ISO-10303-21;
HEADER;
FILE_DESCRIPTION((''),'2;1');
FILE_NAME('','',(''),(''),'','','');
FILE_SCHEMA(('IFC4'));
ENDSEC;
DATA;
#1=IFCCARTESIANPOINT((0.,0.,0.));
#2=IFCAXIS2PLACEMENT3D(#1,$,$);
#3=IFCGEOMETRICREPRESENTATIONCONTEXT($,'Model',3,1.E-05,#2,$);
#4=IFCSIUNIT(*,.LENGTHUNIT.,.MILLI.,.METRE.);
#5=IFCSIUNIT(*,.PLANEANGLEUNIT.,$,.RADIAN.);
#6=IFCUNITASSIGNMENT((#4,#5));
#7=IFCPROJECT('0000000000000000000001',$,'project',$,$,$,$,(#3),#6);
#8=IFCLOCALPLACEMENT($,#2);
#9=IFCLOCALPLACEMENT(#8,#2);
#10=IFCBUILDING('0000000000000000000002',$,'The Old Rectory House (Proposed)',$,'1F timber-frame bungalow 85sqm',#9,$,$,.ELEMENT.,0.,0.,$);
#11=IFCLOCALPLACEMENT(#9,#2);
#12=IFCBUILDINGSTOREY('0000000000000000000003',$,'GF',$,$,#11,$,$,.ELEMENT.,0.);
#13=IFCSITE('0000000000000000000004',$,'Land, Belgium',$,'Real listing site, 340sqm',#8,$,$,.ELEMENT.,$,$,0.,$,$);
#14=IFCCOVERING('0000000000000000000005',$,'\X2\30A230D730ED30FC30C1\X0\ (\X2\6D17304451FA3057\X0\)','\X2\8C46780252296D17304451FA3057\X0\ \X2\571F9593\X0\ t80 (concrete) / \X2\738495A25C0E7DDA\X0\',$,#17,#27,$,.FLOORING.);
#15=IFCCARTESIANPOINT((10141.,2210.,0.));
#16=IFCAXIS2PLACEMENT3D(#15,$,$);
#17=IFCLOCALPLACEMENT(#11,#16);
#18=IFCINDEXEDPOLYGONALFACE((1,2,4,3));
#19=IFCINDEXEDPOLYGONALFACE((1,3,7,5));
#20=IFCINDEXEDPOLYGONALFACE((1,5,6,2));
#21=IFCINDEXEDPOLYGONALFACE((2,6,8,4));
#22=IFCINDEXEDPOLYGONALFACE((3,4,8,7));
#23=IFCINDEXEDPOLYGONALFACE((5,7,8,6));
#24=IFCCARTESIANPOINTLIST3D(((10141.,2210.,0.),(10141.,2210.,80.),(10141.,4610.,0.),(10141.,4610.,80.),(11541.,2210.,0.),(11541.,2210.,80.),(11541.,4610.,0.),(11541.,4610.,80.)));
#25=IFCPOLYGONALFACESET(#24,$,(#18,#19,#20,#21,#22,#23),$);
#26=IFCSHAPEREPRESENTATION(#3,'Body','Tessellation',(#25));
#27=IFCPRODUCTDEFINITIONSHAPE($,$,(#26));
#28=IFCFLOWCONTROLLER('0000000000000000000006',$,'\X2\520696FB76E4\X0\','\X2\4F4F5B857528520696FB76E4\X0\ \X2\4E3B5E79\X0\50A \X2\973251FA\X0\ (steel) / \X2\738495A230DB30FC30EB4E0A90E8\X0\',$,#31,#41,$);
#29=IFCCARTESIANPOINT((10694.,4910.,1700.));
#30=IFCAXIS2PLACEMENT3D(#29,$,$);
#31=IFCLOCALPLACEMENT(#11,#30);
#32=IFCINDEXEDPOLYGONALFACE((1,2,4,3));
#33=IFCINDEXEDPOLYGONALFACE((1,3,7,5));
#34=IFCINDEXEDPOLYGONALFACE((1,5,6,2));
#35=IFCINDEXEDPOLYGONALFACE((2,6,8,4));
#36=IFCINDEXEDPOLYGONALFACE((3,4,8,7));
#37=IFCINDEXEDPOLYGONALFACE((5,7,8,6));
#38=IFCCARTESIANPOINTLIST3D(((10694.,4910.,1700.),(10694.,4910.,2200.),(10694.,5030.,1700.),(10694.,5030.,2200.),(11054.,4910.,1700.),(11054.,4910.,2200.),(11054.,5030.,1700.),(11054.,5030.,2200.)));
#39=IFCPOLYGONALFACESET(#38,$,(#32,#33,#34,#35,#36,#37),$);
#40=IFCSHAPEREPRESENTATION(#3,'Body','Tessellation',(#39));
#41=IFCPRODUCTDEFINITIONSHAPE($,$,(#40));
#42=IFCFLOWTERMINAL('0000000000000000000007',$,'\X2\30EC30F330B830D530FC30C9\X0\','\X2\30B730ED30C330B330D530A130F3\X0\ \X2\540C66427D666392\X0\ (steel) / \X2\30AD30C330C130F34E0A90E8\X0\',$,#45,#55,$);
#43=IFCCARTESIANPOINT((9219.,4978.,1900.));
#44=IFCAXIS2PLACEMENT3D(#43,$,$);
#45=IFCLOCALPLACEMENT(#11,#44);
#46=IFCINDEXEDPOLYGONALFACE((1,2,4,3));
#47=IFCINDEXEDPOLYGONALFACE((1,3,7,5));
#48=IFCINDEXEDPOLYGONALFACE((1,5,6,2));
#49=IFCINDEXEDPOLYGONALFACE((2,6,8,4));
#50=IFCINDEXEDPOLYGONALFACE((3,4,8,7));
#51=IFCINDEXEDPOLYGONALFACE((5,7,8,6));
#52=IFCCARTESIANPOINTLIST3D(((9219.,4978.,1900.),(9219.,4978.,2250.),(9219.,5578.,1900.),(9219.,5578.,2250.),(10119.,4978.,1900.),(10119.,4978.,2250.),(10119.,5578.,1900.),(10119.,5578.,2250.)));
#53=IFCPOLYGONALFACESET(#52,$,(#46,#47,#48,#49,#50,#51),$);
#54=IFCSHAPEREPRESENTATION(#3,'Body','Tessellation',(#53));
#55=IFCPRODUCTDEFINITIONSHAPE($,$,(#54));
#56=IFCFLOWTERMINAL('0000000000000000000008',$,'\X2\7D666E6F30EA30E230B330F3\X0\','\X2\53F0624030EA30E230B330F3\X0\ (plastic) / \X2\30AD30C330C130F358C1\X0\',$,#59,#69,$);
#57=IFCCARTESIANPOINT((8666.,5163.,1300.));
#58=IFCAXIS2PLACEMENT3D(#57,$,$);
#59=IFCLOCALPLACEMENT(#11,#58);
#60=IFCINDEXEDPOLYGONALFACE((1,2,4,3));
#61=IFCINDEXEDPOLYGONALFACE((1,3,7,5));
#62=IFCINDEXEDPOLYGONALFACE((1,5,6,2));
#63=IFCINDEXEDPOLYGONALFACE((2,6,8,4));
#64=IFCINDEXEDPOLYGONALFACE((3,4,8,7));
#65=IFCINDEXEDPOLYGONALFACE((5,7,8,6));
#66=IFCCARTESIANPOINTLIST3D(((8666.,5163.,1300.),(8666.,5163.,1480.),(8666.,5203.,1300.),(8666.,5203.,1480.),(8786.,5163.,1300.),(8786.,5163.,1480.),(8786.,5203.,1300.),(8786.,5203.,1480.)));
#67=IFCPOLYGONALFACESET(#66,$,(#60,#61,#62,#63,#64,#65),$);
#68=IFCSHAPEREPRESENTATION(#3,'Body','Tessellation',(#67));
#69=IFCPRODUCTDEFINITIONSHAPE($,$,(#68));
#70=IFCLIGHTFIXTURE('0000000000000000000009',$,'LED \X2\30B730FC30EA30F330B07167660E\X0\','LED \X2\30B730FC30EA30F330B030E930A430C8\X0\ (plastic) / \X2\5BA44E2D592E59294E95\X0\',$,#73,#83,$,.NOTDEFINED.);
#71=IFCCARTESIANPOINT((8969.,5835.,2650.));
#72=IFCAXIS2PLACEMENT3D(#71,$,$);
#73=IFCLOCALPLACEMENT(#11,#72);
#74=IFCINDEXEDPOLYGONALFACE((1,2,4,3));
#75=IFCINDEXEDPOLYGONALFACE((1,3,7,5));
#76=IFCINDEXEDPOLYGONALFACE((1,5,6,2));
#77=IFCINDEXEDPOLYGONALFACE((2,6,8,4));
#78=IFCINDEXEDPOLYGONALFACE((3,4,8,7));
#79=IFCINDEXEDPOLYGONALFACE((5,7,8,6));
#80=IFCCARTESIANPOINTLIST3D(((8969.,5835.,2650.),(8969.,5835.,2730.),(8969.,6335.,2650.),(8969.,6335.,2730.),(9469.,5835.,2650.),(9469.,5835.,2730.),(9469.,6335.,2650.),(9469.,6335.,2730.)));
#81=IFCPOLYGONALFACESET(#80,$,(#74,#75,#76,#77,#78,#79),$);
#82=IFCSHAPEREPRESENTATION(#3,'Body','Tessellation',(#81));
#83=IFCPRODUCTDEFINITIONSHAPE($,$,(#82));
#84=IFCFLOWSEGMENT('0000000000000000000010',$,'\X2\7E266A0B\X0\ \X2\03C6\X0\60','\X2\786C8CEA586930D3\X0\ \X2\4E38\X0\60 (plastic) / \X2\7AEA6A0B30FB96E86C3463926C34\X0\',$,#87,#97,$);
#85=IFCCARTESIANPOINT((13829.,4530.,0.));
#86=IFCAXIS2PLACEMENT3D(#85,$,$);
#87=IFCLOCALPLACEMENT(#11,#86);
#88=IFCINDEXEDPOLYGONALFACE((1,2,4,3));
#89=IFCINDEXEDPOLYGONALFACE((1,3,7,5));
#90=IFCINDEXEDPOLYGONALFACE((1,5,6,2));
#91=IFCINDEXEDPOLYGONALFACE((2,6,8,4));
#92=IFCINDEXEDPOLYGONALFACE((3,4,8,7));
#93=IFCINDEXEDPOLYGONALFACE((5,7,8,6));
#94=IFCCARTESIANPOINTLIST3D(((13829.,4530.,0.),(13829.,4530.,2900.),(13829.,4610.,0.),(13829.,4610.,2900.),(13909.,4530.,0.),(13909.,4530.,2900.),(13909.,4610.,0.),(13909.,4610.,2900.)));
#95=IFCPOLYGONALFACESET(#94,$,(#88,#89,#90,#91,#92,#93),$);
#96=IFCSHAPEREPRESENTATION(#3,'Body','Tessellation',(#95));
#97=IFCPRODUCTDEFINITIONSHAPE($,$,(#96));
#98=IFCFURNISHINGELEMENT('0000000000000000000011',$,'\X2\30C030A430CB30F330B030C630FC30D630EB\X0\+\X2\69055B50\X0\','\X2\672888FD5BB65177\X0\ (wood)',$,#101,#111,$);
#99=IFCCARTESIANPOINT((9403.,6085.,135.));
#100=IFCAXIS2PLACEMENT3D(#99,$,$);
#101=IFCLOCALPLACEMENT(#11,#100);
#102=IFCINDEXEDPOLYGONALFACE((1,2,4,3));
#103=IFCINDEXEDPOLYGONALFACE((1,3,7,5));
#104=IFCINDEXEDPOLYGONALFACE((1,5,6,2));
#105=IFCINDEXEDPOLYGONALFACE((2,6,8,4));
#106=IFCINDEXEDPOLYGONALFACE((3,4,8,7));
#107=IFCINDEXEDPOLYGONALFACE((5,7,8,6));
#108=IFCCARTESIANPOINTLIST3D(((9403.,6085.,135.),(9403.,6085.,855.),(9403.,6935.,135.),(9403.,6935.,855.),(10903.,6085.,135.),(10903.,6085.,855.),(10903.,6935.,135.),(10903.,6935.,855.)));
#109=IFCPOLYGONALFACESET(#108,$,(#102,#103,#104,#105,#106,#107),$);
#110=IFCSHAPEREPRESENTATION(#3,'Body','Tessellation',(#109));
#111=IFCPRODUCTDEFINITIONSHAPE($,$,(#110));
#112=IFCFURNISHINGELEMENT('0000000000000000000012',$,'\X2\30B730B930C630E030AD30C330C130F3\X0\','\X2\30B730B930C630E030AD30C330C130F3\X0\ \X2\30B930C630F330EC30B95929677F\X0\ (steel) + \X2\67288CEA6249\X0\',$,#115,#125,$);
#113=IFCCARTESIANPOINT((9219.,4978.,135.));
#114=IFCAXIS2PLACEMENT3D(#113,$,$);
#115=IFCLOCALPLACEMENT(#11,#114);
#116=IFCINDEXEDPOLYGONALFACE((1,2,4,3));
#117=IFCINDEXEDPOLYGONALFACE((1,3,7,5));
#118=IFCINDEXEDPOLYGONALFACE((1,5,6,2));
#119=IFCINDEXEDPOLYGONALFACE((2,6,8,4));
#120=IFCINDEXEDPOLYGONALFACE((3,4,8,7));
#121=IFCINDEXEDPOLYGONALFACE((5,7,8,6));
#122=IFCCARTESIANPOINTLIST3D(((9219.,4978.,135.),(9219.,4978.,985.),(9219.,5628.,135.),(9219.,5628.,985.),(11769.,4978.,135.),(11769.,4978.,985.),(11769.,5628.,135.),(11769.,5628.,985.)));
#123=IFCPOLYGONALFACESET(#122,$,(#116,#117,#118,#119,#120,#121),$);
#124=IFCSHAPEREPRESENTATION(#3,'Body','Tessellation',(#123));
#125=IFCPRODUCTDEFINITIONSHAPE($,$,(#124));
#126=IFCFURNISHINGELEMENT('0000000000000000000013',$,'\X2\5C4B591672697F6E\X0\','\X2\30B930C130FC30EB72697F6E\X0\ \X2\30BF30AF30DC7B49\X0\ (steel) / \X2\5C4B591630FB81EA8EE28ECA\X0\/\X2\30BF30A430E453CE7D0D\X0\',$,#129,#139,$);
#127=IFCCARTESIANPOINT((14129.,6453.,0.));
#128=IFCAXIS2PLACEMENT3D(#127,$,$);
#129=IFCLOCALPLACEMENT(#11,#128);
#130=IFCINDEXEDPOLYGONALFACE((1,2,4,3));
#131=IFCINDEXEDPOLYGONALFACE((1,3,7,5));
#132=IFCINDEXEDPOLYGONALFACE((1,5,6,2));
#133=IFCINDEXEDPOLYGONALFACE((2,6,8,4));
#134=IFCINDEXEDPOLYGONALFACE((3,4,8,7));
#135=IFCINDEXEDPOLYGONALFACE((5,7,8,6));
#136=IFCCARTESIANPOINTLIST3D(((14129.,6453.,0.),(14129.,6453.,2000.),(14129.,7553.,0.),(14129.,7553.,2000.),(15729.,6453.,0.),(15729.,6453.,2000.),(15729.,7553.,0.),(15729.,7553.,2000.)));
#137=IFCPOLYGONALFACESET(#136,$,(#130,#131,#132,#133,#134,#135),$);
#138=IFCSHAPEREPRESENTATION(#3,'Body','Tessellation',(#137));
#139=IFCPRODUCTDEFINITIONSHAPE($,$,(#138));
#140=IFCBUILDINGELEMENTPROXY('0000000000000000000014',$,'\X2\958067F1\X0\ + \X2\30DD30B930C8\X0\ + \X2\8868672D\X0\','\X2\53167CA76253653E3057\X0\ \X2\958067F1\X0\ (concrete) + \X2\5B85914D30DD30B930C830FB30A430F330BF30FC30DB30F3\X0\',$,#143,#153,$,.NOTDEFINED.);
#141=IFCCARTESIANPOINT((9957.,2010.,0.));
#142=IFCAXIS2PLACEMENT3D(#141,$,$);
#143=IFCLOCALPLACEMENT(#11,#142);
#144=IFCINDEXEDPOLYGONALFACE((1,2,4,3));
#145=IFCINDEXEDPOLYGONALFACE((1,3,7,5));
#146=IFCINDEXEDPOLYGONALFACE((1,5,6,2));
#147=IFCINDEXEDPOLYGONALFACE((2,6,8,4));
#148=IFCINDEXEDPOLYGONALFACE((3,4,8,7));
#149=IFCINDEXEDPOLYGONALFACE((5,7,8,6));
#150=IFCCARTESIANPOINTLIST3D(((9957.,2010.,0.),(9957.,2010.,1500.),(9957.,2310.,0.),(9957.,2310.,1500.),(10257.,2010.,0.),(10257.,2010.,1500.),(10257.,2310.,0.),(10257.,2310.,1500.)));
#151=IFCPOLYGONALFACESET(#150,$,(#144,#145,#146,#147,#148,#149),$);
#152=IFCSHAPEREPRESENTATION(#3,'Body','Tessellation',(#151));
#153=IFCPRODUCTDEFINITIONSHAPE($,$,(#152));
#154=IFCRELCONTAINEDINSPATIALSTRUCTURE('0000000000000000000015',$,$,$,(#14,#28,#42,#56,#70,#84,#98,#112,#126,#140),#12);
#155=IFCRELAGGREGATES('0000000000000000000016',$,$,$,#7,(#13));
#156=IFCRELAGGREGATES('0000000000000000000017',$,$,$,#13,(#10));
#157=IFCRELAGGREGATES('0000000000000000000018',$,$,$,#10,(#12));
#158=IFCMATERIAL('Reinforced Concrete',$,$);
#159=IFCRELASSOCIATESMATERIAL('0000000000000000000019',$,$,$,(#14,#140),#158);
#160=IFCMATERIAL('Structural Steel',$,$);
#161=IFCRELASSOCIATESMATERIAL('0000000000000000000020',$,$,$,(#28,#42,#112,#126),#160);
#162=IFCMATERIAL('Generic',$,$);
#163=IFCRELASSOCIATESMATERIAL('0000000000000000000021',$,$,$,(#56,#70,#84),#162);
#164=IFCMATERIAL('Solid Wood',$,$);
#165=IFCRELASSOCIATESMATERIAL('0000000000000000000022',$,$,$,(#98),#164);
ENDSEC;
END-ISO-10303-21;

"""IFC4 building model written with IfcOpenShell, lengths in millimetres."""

from ifc_helpers import new_model, si_unit, frame, frame_2d, origin, place, context, project, spatial, rectangle, extrude, material, element, save


model = new_model("IFC4")

# Units and contexts
model_context = context("Model", 3, precision=1e-05, world=origin())
ifc_project = project(units=[si_unit("LENGTHUNIT", "METRE", prefix="MILLI"), si_unit("PLANEANGLEUNIT", "RADIAN")], contexts=[model_context])

# Site, building, storey
site_placement = place(None, origin())
site = spatial("IfcSite", under=ifc_project, at=site_placement, Name="Land, Belgium", ObjectType="Real listing site, 340sqm", CompositionType="ELEMENT", RefElevation=0.0)
building_placement = place(site_placement, origin())
building = spatial("IfcBuilding", under=site, at=building_placement, Name="The Old Rectory House (Proposed)", ObjectType="1F timber-frame bungalow 85sqm", CompositionType="ELEMENT", ElevationOfRefHeight=0.0, ElevationOfTerrain=0.0)
storey_placement = place(building_placement, origin())
storey = spatial("IfcBuildingStorey", under=building, at=storey_placement, Name="GF", CompositionType="ELEMENT", Elevation=0.0)

# Shared definitions
ifc_material_1 = material(Name="Solid Wood")

# Shared definitions
ifc_material_2 = material(Name="Structural Steel")

# Covering
ifc_material_3 = material(Name="Reinforced Concrete")
covering_placement = place(storey_placement, frame((10141.0, 2210.0, 0.0)))
element("IfcCovering", 1, at=covering_placement, inside=storey, material=ifc_material_3, Name="アプローチ (洗い出し)", Description="豆砂利洗い出し 土間 t80 (concrete) / 玄関導線", PredefinedType="FLOORING", context=model_context, shape_type="SweptSolid", body=[
    extrude(rectangle(XDim=1400.0, YDim=2400.0, at=frame_2d((700.0, 1200.0))), frame((10141.0, 2210.0, 0.0)), (0.0, 0.0, 1.0), 80.0),
])

# Flow controller
flow_controller_placement = place(storey_placement, frame((10694.0, 4910.0, 1700.0)))
element("IfcFlowController", 2, at=flow_controller_placement, inside=storey, material=ifc_material_2, Name="分電盤", Description="住宅用分電盤 主幹50A 露出 (steel) / 玄関ホール上部", context=model_context, shape_type="SweptSolid", body=[
    extrude(rectangle(XDim=360.0, YDim=120.0, at=frame_2d((180.0, 60.0))), frame((10694.0, 4910.0, 1700.0)), (0.0, 0.0, 1.0), 500.0),
])

# Flow terminals
flow_terminal_1_placement = place(storey_placement, frame((9219.0, 4978.0, 1900.0)))
element("IfcFlowTerminal", 3, at=flow_terminal_1_placement, inside=storey, material=ifc_material_2, Name="レンジフード", Description="シロッコファン 同時給排 (steel) / キッチン上部", context=model_context, shape_type="SweptSolid", body=[
    extrude(rectangle(XDim=900.0, YDim=600.0, at=frame_2d((450.0, 300.0))), frame((9219.0, 4978.0, 1900.0)), (0.0, 0.0, 1.0), 350.0),
])
ifc_material_4 = material(Name="Generic")
flow_terminal_2_placement = place(storey_placement, frame((8666.0, 5163.0, 1300.0)))
element("IfcFlowTerminal", 4, at=flow_terminal_2_placement, inside=storey, material=ifc_material_4, Name="給湯リモコン", Description="台所リモコン (plastic) / キッチン壁", context=model_context, shape_type="SweptSolid", body=[
    extrude(rectangle(XDim=120.0, YDim=40.0, at=frame_2d((60.0, 20.0))), frame((8666.0, 5163.0, 1300.0)), (0.0, 0.0, 1.0), 180.0),
])

# Light fixture
light_fixture_placement = place(storey_placement, frame((8969.0, 5835.0, 2650.0)))
element("IfcLightFixture", 5, at=light_fixture_placement, inside=storey, material=ifc_material_4, Name="LED シーリング照明", Description="LED シーリングライト (plastic) / 室中央天井", PredefinedType="NOTDEFINED", context=model_context, shape_type="SweptSolid", body=[
    extrude(rectangle(XDim=500.0, YDim=500.0, at=frame_2d((250.0, 250.0))), frame((8969.0, 5835.0, 2650.0)), (0.0, 0.0, 1.0), 80.0),
])

# Flow segment
flow_segment_placement = place(storey_placement, frame((13829.0, 4530.0, 0.0)))
element("IfcFlowSegment", 6, at=flow_segment_placement, inside=storey, material=ifc_material_4, Name="縦樋 φ60", Description="硬質塩ビ 丸60 (plastic) / 竪樋・雨水排水", context=model_context, shape_type="SweptSolid", body=[
    extrude(rectangle(XDim=80.0, YDim=80.0, at=frame_2d((40.0, 40.0))), frame((13829.0, 4530.0, 0.0)), (0.0, 0.0, 1.0), 2900.0),
])

# Furnishing elements
furnishing_1_placement = place(storey_placement, frame((9403.0, 6085.0, 135.0)))
element("IfcFurnishingElement", 7, at=furnishing_1_placement, inside=storey, material=ifc_material_1, Name="ダイニングテーブル+椅子", Description="木製家具 (wood)", context=model_context, shape_type="SweptSolid", body=[
    extrude(rectangle(XDim=1500.0, YDim=850.0, at=frame_2d((750.0, 425.0))), frame((9403.0, 6085.0, 135.0)), (0.0, 0.0, 1.0), 720.0),
])
furnishing_2_placement = place(storey_placement, frame((9219.0, 4978.0, 135.0)))
element("IfcFurnishingElement", 8, at=furnishing_2_placement, inside=storey, material=ifc_material_2, Name="システムキッチン", Description="システムキッチン ステンレス天板 (steel) + 木質扉", context=model_context, shape_type="SweptSolid", body=[
    extrude(rectangle(XDim=2550.0, YDim=650.0, at=frame_2d((1275.0, 325.0))), frame((9219.0, 4978.0, 135.0)), (0.0, 0.0, 1.0), 850.0),
])
furnishing_3_placement = place(storey_placement, frame((14129.0, 6453.0, 0.0)))
element("IfcFurnishingElement", 9, at=furnishing_3_placement, inside=storey, material=ifc_material_2, Name="屋外物置", Description="スチール物置 タクボ等 (steel) / 屋外・自転車/タイヤ収納", context=model_context, shape_type="SweptSolid", body=[
    extrude(rectangle(XDim=1600.0, YDim=1100.0, at=frame_2d((800.0, 550.0))), frame((14129.0, 6453.0, 0.0)), (0.0, 0.0, 1.0), 2000.0),
])

# Building element proxy
proxy_placement = place(storey_placement, frame((9957.0, 2010.0, 0.0)))
element("IfcBuildingElementProxy", 10, at=proxy_placement, inside=storey, material=ifc_material_3, Name="門柱 + ポスト + 表札", Description="化粧打放し 門柱 (concrete) + 宅配ポスト・インターホン", PredefinedType="NOTDEFINED", context=model_context, shape_type="SweptSolid", body=[
    extrude(rectangle(XDim=300.0, YDim=300.0, at=frame_2d((150.0, 150.0))), frame((9957.0, 2010.0, 0.0)), (0.0, 0.0, 1.0), 1500.0),
])

save(model, "model.ifc")
